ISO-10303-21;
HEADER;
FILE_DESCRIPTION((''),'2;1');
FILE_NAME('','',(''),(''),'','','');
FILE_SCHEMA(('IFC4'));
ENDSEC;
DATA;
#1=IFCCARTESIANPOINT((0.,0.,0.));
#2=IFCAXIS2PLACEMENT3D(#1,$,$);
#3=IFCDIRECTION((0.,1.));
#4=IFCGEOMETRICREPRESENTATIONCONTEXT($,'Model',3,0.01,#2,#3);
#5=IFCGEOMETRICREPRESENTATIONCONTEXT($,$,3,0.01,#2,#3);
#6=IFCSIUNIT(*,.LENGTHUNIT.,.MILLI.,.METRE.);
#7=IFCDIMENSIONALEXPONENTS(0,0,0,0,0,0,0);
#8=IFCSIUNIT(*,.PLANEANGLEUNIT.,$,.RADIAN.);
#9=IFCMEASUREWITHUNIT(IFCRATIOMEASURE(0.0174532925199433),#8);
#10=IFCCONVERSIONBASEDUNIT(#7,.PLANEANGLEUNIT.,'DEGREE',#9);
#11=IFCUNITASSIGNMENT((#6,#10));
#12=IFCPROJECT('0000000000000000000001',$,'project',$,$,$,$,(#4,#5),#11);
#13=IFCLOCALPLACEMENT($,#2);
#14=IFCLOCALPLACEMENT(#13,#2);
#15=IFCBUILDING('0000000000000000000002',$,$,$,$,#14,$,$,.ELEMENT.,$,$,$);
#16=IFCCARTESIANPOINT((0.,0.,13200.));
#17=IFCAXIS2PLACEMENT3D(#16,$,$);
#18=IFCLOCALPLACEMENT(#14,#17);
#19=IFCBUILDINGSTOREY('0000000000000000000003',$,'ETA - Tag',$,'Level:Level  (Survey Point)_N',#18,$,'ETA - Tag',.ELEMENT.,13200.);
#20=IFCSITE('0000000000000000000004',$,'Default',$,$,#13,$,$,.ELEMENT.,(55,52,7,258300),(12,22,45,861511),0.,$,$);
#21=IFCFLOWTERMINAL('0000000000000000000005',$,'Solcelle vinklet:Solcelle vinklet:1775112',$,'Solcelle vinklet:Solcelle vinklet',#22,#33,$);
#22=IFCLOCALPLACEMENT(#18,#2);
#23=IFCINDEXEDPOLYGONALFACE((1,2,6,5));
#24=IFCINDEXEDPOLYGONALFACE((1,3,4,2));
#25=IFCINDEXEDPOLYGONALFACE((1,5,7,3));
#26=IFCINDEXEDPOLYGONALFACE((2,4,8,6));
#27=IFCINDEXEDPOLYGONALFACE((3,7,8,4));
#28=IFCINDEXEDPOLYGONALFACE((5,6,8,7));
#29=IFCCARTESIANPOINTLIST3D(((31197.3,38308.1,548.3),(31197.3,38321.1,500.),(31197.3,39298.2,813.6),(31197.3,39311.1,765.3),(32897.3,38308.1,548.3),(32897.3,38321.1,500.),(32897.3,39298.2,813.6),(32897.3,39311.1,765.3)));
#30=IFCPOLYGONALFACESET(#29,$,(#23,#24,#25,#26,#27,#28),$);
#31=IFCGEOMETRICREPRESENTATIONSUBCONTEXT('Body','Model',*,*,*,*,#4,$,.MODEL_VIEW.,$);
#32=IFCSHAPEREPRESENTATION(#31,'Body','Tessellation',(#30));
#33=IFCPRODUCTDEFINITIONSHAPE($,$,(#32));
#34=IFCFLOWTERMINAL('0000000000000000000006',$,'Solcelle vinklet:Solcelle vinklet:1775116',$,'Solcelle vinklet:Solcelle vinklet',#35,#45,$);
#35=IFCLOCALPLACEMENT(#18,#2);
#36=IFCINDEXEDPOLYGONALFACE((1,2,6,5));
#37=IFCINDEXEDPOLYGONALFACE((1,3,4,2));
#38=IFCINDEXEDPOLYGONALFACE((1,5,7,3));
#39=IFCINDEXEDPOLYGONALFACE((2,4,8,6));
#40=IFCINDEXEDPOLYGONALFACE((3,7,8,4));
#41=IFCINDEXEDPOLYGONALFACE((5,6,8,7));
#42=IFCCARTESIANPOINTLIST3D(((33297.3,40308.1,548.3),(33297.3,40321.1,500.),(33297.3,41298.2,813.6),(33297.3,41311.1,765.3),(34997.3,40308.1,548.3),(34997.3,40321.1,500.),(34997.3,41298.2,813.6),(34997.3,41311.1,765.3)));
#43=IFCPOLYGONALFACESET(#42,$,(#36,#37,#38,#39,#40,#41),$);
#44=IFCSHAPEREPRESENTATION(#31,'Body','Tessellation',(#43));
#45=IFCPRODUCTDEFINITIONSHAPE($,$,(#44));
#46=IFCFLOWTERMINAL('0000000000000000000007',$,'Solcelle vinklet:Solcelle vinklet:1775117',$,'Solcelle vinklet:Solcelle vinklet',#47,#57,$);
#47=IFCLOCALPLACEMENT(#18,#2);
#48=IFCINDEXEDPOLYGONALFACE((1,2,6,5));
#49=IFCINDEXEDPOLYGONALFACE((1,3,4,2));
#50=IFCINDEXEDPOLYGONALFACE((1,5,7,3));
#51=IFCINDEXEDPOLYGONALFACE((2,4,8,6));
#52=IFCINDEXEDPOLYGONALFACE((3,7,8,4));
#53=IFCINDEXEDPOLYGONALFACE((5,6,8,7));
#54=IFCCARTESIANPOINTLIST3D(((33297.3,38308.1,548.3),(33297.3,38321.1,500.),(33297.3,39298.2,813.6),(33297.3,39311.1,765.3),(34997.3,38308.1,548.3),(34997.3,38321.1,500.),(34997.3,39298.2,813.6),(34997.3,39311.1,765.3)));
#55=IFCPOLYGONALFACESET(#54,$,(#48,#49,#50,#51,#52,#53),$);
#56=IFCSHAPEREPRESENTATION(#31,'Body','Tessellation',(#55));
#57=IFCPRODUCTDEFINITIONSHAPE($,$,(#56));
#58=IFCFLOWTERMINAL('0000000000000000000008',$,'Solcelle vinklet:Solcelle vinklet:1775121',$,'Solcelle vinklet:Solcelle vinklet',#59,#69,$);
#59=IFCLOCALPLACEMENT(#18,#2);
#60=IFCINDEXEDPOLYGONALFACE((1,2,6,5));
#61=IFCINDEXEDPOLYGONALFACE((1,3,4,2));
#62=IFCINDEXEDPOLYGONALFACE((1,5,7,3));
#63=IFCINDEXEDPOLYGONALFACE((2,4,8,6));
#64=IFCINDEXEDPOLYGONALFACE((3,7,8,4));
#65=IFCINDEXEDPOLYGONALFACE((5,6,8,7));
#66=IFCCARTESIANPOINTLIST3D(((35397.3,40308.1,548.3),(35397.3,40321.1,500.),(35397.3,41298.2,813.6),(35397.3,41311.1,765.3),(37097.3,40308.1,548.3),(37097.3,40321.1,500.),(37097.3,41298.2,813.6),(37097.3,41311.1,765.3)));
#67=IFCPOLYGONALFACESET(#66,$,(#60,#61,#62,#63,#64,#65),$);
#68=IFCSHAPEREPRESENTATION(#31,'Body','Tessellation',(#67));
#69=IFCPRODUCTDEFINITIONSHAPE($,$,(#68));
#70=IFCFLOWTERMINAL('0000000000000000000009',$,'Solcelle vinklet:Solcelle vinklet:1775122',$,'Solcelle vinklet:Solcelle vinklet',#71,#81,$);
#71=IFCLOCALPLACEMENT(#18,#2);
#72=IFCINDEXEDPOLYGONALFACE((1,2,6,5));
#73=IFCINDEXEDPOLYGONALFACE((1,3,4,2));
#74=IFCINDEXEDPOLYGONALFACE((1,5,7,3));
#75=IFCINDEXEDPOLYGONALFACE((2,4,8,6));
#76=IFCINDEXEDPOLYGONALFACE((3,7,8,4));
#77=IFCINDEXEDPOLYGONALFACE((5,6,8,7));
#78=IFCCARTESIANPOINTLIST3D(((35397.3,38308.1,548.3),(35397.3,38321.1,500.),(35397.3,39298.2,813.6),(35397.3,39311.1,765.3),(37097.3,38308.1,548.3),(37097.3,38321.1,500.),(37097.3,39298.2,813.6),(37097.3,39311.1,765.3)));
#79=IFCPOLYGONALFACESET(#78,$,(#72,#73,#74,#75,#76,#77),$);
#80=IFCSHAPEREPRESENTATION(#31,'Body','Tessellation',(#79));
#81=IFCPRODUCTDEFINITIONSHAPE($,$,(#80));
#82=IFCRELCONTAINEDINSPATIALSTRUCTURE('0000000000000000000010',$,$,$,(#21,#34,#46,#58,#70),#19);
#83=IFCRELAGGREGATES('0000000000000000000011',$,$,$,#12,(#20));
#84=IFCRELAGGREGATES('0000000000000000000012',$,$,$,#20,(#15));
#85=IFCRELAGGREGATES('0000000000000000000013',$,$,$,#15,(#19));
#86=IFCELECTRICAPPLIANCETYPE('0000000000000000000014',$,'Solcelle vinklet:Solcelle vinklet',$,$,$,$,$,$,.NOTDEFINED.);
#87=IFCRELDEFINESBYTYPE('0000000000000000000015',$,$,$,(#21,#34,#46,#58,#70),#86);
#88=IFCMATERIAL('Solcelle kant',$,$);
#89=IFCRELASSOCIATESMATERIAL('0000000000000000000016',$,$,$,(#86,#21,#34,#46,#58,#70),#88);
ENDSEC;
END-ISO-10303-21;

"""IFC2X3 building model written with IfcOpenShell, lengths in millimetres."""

from ifc_helpers import new_model, entity, si_unit, converted_unit, direction, frame, frame_2d, origin, place, context, subcontext, project, spatial, rectangle, extrude, source, transform, mapped, material, type_object, type_shapes, element, save


model = new_model("IFC2X3")

# Units and contexts
model_context = context("Model", 3, precision=0.01, world=origin(), true_north=direction((0.0, 1.0)))
context_of_model = context(None, 3, precision=0.01, world=origin(), true_north=direction((0.0, 1.0)))
body_context = subcontext(model_context, "Body", "Model", "MODEL_VIEW")
ifc_project = project(units=[si_unit("LENGTHUNIT", "METRE", prefix="MILLI"), converted_unit("PLANEANGLEUNIT", "DEGREE", entity("IfcRatioMeasure", 0.0174532925199433), si_unit("PLANEANGLEUNIT", "RADIAN"), dimensions=[0, 0, 0, 0, 0, 0, 0])], contexts=[model_context, context_of_model])

# Site, building, storey
site_placement = place(None, origin())
site = spatial("IfcSite", under=ifc_project, at=site_placement, Name="Default", CompositionType="ELEMENT", RefLatitude=(55, 52, 7, 258300), RefLongitude=(12, 22, 45, 861511), RefElevation=0.0)
building_placement = place(site_placement, origin())
building = spatial("IfcBuilding", under=site, at=building_placement, CompositionType="ELEMENT")
storey_placement = place(building_placement, frame((0.0, 0.0, 13200.0)))
storey = spatial("IfcBuildingStorey", under=building, at=storey_placement, Name="ETA - Tag", ObjectType="Level:Level  (Survey Point)_N", LongName="ETA - Tag", CompositionType="ELEMENT", Elevation=13200.0)

# Flow terminals
ifc_material = material(Name="Solcelle kant")
electric_appliance_type = type_object("IfcElectricApplianceType", Name="Solcelle vinklet:Solcelle vinklet", PredefinedType="NOTDEFINED", material=ifc_material)
shared_shape = source(origin(), body_context, "Body", "SweptSolid", [
    extrude(rectangle(XDim=50.0, YDim=1025.0, at=frame_2d((0.0, 0.0), x_axis=(1.0, 0.0))), frame((-850.0, 488.6, 156.8), z_axis=(1.0, 0.0, 0.0), x_axis=(0.0, 0.258819, -0.965926)), (0.0, 0.0, 1.0), 1700.0),
])
type_shapes(electric_appliance_type, [shared_shape])
for number, where, name in (
    (1, (32047.3, 38321.1, 500.0), "Solcelle vinklet:Solcelle vinklet:1775112"),
    (2, (34147.3, 40321.1, 500.0), "Solcelle vinklet:Solcelle vinklet:1775116"),
    (3, (34147.3, 38321.1, 500.0), "Solcelle vinklet:Solcelle vinklet:1775117"),
    (4, (36247.3, 40321.1, 500.0), "Solcelle vinklet:Solcelle vinklet:1775121"),
    (5, (36247.3, 38321.1, 500.0), "Solcelle vinklet:Solcelle vinklet:1775122"),
):
    element("IfcFlowTerminal", number, at=place(storey_placement, frame(where)), inside=storey, type_object=electric_appliance_type, material=ifc_material, Name=name, ObjectType="Solcelle vinklet:Solcelle vinklet", context=body_context, shape_type="MappedRepresentation", body=[
        mapped(shared_shape, transform((0.0, 0.0, 0.0), scale=1.0)),
    ])

save(model, "model.ifc")
